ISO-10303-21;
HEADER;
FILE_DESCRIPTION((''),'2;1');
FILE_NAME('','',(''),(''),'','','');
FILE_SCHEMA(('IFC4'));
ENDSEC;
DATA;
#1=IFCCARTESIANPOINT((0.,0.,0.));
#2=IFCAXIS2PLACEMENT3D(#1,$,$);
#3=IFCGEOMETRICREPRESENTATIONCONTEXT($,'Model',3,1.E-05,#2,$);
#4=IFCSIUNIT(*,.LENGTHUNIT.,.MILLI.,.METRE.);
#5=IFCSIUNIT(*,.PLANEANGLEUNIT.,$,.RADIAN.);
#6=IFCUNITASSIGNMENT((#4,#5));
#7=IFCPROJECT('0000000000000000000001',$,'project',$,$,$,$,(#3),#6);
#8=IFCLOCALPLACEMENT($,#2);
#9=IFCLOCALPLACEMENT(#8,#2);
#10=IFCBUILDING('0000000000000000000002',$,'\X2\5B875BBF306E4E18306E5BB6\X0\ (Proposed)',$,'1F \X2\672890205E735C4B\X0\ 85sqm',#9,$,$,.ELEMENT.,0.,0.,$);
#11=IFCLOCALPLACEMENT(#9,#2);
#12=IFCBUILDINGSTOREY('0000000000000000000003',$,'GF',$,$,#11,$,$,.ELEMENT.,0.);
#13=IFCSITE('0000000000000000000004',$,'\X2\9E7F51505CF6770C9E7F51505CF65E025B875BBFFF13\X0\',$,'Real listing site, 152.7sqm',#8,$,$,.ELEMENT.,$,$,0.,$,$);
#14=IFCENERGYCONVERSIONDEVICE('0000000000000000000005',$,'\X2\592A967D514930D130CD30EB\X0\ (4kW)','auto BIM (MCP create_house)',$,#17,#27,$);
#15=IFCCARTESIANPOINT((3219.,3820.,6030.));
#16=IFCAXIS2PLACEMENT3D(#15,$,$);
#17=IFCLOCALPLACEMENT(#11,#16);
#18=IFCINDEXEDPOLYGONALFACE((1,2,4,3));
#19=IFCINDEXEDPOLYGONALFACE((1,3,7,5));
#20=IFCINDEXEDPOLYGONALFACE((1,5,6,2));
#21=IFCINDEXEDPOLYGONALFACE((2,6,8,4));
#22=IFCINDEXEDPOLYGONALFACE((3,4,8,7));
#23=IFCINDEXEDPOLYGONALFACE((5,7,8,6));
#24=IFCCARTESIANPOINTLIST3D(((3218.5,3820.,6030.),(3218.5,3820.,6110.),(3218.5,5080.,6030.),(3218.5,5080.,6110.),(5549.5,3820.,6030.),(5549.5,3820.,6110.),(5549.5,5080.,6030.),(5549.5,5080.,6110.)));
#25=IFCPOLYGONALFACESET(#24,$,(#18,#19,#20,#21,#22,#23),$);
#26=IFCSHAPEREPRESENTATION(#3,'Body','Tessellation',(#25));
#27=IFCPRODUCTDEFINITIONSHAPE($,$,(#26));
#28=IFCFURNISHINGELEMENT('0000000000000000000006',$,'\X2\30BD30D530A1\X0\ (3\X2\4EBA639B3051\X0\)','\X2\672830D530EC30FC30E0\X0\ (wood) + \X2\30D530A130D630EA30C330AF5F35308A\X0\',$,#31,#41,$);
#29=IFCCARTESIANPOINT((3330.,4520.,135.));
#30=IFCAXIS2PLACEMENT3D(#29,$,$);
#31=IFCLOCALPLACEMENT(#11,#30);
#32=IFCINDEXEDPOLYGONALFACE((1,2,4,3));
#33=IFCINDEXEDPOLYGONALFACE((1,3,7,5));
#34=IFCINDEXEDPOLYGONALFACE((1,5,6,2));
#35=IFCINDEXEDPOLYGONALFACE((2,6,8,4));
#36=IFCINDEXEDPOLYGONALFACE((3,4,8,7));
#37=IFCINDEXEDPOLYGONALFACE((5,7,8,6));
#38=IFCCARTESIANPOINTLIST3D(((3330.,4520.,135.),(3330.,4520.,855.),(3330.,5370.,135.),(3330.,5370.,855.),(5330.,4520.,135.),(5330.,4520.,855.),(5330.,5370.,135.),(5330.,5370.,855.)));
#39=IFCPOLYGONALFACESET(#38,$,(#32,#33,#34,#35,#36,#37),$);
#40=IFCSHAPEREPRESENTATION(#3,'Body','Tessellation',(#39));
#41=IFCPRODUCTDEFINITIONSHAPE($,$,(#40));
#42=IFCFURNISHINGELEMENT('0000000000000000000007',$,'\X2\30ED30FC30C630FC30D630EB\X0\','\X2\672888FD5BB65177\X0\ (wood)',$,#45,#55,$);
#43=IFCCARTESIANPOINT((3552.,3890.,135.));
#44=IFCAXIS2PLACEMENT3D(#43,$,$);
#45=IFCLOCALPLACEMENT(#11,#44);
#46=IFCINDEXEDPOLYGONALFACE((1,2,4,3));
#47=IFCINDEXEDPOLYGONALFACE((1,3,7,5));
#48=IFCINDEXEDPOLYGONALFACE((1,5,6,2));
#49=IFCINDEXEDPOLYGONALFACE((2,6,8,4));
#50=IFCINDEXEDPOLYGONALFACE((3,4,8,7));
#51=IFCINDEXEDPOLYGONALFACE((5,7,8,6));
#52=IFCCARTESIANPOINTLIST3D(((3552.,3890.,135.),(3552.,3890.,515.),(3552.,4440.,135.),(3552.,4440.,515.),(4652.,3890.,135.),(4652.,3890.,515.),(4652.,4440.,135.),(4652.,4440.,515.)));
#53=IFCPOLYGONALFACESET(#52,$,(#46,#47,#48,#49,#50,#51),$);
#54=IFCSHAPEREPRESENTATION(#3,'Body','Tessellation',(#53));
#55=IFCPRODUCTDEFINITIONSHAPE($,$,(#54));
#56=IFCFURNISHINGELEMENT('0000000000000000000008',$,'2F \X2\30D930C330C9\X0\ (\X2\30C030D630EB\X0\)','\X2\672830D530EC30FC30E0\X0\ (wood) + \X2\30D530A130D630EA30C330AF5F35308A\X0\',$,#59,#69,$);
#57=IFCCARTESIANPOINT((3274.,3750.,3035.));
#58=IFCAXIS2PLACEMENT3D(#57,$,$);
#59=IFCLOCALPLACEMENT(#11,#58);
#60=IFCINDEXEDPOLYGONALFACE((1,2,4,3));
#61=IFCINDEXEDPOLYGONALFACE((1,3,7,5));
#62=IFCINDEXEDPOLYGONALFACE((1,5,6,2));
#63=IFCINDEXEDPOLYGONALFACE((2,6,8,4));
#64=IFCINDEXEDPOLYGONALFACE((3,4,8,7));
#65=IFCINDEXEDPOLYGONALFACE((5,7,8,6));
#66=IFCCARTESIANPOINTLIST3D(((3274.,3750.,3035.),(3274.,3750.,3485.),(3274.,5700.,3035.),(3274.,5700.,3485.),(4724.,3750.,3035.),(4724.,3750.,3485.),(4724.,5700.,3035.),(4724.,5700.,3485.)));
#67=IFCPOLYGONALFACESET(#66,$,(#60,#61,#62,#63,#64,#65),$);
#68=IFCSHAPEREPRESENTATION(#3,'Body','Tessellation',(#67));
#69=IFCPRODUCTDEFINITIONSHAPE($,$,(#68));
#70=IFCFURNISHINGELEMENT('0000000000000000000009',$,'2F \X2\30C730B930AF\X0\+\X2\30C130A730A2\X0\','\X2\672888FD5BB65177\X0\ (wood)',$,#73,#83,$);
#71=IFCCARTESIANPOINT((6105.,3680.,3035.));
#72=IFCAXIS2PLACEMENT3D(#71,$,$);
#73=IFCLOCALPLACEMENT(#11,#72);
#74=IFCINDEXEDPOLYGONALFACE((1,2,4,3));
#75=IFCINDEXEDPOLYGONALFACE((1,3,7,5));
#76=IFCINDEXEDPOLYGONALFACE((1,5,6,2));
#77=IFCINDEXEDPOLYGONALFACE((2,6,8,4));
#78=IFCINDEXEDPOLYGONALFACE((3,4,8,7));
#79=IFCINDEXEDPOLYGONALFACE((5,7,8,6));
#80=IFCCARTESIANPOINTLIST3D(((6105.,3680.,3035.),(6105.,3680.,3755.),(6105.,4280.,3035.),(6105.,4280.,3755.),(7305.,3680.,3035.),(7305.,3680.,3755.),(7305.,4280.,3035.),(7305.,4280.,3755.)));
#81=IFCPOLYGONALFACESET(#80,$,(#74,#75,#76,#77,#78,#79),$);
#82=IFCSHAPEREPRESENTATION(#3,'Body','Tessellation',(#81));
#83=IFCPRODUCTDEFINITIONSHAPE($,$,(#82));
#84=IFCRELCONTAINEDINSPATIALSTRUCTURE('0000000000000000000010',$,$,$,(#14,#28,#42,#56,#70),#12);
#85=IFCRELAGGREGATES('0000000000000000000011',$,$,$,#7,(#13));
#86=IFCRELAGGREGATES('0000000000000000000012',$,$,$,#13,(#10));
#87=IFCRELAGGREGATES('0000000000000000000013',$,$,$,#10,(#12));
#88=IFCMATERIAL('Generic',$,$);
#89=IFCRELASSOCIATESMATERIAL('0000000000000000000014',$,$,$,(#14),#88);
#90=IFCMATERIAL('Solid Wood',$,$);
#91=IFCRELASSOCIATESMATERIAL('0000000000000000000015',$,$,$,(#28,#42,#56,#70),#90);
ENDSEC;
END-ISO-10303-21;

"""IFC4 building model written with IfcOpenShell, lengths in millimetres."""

from ifc_helpers import new_model, si_unit, frame, frame_2d, origin, place, context, project, spatial, rectangle, extrude, material, element, save


model = new_model("IFC4")

# Units and contexts
model_context = context("Model", 3, precision=1e-05, world=origin())
ifc_project = project(units=[si_unit("LENGTHUNIT", "METRE", prefix="MILLI"), si_unit("PLANEANGLEUNIT", "RADIAN")], contexts=[model_context])

# Site, building, storey
site_placement = place(None, origin())
site = spatial("IfcSite", under=ifc_project, at=site_placement, Name="鹿児島県鹿児島市宇宿３", ObjectType="Real listing site, 152.7sqm", CompositionType="ELEMENT", RefElevation=0.0)
building_placement = place(site_placement, origin())
building = spatial("IfcBuilding", under=site, at=building_placement, Name="宇宿の丘の家 (Proposed)", ObjectType="1F 木造平屋 85sqm", CompositionType="ELEMENT", ElevationOfRefHeight=0.0, ElevationOfTerrain=0.0)
storey_placement = place(building_placement, origin())
storey = spatial("IfcBuildingStorey", under=building, at=storey_placement, Name="GF", CompositionType="ELEMENT", Elevation=0.0)

# Shared definitions
ifc_material_1 = material(Name="Solid Wood")

# Shared definitions
ifc_material_2 = material(Name="Generic")

# Energy conversion device
energy_conversion_device_placement = place(storey_placement, frame((3219.0, 3820.0, 6030.0)))
element("IfcEnergyConversionDevice", 1, at=energy_conversion_device_placement, inside=storey, material=ifc_material_2, Name="太陽光パネル (4kW)", Description="auto BIM (MCP create_house)", context=model_context, shape_type="SweptSolid", body=[
    extrude(rectangle(XDim=2331.0, YDim=1260.0, at=frame_2d((1165.0, 630.0))), frame((3219.0, 3820.0, 6030.0)), (0.0, 0.0, 1.0), 80.0),
])

# Furnishing elements
furnishing_1_placement = place(storey_placement, frame((3330.0, 4520.0, 135.0)))
element("IfcFurnishingElement", 2, at=furnishing_1_placement, inside=storey, material=ifc_material_1, Name="ソファ (3人掛け)", Description="木フレーム (wood) + ファブリック張り", context=model_context, shape_type="SweptSolid", body=[
    extrude(rectangle(XDim=2000.0, YDim=850.0, at=frame_2d((1000.0, 425.0))), frame((3330.0, 4520.0, 135.0)), (0.0, 0.0, 1.0), 720.0),
])
furnishing_2_placement = place(storey_placement, frame((3552.0, 3890.0, 135.0)))
element("IfcFurnishingElement", 3, at=furnishing_2_placement, inside=storey, material=ifc_material_1, Name="ローテーブル", Description="木製家具 (wood)", context=model_context, shape_type="SweptSolid", body=[
    extrude(rectangle(XDim=1100.0, YDim=550.0, at=frame_2d((550.0, 275.0))), frame((3552.0, 3890.0, 135.0)), (0.0, 0.0, 1.0), 380.0),
])
furnishing_3_placement = place(storey_placement, frame((3274.0, 3750.0, 3035.0)))
element("IfcFurnishingElement", 4, at=furnishing_3_placement, inside=storey, material=ifc_material_1, Name="2F ベッド (ダブル)", Description="木フレーム (wood) + ファブリック張り", context=model_context, shape_type="SweptSolid", body=[
    extrude(rectangle(XDim=1450.0, YDim=1950.0, at=frame_2d((725.0, 975.0))), frame((3274.0, 3750.0, 3035.0)), (0.0, 0.0, 1.0), 450.0),
])
furnishing_4_placement = place(storey_placement, frame((6105.0, 3680.0, 3035.0)))
element("IfcFurnishingElement", 5, at=furnishing_4_placement, inside=storey, material=ifc_material_1, Name="2F デスク+チェア", Description="木製家具 (wood)", context=model_context, shape_type="SweptSolid", body=[
    extrude(rectangle(XDim=1200.0, YDim=600.0, at=frame_2d((600.0, 300.0))), frame((6105.0, 3680.0, 3035.0)), (0.0, 0.0, 1.0), 720.0),
])

save(model, "model.ifc")
